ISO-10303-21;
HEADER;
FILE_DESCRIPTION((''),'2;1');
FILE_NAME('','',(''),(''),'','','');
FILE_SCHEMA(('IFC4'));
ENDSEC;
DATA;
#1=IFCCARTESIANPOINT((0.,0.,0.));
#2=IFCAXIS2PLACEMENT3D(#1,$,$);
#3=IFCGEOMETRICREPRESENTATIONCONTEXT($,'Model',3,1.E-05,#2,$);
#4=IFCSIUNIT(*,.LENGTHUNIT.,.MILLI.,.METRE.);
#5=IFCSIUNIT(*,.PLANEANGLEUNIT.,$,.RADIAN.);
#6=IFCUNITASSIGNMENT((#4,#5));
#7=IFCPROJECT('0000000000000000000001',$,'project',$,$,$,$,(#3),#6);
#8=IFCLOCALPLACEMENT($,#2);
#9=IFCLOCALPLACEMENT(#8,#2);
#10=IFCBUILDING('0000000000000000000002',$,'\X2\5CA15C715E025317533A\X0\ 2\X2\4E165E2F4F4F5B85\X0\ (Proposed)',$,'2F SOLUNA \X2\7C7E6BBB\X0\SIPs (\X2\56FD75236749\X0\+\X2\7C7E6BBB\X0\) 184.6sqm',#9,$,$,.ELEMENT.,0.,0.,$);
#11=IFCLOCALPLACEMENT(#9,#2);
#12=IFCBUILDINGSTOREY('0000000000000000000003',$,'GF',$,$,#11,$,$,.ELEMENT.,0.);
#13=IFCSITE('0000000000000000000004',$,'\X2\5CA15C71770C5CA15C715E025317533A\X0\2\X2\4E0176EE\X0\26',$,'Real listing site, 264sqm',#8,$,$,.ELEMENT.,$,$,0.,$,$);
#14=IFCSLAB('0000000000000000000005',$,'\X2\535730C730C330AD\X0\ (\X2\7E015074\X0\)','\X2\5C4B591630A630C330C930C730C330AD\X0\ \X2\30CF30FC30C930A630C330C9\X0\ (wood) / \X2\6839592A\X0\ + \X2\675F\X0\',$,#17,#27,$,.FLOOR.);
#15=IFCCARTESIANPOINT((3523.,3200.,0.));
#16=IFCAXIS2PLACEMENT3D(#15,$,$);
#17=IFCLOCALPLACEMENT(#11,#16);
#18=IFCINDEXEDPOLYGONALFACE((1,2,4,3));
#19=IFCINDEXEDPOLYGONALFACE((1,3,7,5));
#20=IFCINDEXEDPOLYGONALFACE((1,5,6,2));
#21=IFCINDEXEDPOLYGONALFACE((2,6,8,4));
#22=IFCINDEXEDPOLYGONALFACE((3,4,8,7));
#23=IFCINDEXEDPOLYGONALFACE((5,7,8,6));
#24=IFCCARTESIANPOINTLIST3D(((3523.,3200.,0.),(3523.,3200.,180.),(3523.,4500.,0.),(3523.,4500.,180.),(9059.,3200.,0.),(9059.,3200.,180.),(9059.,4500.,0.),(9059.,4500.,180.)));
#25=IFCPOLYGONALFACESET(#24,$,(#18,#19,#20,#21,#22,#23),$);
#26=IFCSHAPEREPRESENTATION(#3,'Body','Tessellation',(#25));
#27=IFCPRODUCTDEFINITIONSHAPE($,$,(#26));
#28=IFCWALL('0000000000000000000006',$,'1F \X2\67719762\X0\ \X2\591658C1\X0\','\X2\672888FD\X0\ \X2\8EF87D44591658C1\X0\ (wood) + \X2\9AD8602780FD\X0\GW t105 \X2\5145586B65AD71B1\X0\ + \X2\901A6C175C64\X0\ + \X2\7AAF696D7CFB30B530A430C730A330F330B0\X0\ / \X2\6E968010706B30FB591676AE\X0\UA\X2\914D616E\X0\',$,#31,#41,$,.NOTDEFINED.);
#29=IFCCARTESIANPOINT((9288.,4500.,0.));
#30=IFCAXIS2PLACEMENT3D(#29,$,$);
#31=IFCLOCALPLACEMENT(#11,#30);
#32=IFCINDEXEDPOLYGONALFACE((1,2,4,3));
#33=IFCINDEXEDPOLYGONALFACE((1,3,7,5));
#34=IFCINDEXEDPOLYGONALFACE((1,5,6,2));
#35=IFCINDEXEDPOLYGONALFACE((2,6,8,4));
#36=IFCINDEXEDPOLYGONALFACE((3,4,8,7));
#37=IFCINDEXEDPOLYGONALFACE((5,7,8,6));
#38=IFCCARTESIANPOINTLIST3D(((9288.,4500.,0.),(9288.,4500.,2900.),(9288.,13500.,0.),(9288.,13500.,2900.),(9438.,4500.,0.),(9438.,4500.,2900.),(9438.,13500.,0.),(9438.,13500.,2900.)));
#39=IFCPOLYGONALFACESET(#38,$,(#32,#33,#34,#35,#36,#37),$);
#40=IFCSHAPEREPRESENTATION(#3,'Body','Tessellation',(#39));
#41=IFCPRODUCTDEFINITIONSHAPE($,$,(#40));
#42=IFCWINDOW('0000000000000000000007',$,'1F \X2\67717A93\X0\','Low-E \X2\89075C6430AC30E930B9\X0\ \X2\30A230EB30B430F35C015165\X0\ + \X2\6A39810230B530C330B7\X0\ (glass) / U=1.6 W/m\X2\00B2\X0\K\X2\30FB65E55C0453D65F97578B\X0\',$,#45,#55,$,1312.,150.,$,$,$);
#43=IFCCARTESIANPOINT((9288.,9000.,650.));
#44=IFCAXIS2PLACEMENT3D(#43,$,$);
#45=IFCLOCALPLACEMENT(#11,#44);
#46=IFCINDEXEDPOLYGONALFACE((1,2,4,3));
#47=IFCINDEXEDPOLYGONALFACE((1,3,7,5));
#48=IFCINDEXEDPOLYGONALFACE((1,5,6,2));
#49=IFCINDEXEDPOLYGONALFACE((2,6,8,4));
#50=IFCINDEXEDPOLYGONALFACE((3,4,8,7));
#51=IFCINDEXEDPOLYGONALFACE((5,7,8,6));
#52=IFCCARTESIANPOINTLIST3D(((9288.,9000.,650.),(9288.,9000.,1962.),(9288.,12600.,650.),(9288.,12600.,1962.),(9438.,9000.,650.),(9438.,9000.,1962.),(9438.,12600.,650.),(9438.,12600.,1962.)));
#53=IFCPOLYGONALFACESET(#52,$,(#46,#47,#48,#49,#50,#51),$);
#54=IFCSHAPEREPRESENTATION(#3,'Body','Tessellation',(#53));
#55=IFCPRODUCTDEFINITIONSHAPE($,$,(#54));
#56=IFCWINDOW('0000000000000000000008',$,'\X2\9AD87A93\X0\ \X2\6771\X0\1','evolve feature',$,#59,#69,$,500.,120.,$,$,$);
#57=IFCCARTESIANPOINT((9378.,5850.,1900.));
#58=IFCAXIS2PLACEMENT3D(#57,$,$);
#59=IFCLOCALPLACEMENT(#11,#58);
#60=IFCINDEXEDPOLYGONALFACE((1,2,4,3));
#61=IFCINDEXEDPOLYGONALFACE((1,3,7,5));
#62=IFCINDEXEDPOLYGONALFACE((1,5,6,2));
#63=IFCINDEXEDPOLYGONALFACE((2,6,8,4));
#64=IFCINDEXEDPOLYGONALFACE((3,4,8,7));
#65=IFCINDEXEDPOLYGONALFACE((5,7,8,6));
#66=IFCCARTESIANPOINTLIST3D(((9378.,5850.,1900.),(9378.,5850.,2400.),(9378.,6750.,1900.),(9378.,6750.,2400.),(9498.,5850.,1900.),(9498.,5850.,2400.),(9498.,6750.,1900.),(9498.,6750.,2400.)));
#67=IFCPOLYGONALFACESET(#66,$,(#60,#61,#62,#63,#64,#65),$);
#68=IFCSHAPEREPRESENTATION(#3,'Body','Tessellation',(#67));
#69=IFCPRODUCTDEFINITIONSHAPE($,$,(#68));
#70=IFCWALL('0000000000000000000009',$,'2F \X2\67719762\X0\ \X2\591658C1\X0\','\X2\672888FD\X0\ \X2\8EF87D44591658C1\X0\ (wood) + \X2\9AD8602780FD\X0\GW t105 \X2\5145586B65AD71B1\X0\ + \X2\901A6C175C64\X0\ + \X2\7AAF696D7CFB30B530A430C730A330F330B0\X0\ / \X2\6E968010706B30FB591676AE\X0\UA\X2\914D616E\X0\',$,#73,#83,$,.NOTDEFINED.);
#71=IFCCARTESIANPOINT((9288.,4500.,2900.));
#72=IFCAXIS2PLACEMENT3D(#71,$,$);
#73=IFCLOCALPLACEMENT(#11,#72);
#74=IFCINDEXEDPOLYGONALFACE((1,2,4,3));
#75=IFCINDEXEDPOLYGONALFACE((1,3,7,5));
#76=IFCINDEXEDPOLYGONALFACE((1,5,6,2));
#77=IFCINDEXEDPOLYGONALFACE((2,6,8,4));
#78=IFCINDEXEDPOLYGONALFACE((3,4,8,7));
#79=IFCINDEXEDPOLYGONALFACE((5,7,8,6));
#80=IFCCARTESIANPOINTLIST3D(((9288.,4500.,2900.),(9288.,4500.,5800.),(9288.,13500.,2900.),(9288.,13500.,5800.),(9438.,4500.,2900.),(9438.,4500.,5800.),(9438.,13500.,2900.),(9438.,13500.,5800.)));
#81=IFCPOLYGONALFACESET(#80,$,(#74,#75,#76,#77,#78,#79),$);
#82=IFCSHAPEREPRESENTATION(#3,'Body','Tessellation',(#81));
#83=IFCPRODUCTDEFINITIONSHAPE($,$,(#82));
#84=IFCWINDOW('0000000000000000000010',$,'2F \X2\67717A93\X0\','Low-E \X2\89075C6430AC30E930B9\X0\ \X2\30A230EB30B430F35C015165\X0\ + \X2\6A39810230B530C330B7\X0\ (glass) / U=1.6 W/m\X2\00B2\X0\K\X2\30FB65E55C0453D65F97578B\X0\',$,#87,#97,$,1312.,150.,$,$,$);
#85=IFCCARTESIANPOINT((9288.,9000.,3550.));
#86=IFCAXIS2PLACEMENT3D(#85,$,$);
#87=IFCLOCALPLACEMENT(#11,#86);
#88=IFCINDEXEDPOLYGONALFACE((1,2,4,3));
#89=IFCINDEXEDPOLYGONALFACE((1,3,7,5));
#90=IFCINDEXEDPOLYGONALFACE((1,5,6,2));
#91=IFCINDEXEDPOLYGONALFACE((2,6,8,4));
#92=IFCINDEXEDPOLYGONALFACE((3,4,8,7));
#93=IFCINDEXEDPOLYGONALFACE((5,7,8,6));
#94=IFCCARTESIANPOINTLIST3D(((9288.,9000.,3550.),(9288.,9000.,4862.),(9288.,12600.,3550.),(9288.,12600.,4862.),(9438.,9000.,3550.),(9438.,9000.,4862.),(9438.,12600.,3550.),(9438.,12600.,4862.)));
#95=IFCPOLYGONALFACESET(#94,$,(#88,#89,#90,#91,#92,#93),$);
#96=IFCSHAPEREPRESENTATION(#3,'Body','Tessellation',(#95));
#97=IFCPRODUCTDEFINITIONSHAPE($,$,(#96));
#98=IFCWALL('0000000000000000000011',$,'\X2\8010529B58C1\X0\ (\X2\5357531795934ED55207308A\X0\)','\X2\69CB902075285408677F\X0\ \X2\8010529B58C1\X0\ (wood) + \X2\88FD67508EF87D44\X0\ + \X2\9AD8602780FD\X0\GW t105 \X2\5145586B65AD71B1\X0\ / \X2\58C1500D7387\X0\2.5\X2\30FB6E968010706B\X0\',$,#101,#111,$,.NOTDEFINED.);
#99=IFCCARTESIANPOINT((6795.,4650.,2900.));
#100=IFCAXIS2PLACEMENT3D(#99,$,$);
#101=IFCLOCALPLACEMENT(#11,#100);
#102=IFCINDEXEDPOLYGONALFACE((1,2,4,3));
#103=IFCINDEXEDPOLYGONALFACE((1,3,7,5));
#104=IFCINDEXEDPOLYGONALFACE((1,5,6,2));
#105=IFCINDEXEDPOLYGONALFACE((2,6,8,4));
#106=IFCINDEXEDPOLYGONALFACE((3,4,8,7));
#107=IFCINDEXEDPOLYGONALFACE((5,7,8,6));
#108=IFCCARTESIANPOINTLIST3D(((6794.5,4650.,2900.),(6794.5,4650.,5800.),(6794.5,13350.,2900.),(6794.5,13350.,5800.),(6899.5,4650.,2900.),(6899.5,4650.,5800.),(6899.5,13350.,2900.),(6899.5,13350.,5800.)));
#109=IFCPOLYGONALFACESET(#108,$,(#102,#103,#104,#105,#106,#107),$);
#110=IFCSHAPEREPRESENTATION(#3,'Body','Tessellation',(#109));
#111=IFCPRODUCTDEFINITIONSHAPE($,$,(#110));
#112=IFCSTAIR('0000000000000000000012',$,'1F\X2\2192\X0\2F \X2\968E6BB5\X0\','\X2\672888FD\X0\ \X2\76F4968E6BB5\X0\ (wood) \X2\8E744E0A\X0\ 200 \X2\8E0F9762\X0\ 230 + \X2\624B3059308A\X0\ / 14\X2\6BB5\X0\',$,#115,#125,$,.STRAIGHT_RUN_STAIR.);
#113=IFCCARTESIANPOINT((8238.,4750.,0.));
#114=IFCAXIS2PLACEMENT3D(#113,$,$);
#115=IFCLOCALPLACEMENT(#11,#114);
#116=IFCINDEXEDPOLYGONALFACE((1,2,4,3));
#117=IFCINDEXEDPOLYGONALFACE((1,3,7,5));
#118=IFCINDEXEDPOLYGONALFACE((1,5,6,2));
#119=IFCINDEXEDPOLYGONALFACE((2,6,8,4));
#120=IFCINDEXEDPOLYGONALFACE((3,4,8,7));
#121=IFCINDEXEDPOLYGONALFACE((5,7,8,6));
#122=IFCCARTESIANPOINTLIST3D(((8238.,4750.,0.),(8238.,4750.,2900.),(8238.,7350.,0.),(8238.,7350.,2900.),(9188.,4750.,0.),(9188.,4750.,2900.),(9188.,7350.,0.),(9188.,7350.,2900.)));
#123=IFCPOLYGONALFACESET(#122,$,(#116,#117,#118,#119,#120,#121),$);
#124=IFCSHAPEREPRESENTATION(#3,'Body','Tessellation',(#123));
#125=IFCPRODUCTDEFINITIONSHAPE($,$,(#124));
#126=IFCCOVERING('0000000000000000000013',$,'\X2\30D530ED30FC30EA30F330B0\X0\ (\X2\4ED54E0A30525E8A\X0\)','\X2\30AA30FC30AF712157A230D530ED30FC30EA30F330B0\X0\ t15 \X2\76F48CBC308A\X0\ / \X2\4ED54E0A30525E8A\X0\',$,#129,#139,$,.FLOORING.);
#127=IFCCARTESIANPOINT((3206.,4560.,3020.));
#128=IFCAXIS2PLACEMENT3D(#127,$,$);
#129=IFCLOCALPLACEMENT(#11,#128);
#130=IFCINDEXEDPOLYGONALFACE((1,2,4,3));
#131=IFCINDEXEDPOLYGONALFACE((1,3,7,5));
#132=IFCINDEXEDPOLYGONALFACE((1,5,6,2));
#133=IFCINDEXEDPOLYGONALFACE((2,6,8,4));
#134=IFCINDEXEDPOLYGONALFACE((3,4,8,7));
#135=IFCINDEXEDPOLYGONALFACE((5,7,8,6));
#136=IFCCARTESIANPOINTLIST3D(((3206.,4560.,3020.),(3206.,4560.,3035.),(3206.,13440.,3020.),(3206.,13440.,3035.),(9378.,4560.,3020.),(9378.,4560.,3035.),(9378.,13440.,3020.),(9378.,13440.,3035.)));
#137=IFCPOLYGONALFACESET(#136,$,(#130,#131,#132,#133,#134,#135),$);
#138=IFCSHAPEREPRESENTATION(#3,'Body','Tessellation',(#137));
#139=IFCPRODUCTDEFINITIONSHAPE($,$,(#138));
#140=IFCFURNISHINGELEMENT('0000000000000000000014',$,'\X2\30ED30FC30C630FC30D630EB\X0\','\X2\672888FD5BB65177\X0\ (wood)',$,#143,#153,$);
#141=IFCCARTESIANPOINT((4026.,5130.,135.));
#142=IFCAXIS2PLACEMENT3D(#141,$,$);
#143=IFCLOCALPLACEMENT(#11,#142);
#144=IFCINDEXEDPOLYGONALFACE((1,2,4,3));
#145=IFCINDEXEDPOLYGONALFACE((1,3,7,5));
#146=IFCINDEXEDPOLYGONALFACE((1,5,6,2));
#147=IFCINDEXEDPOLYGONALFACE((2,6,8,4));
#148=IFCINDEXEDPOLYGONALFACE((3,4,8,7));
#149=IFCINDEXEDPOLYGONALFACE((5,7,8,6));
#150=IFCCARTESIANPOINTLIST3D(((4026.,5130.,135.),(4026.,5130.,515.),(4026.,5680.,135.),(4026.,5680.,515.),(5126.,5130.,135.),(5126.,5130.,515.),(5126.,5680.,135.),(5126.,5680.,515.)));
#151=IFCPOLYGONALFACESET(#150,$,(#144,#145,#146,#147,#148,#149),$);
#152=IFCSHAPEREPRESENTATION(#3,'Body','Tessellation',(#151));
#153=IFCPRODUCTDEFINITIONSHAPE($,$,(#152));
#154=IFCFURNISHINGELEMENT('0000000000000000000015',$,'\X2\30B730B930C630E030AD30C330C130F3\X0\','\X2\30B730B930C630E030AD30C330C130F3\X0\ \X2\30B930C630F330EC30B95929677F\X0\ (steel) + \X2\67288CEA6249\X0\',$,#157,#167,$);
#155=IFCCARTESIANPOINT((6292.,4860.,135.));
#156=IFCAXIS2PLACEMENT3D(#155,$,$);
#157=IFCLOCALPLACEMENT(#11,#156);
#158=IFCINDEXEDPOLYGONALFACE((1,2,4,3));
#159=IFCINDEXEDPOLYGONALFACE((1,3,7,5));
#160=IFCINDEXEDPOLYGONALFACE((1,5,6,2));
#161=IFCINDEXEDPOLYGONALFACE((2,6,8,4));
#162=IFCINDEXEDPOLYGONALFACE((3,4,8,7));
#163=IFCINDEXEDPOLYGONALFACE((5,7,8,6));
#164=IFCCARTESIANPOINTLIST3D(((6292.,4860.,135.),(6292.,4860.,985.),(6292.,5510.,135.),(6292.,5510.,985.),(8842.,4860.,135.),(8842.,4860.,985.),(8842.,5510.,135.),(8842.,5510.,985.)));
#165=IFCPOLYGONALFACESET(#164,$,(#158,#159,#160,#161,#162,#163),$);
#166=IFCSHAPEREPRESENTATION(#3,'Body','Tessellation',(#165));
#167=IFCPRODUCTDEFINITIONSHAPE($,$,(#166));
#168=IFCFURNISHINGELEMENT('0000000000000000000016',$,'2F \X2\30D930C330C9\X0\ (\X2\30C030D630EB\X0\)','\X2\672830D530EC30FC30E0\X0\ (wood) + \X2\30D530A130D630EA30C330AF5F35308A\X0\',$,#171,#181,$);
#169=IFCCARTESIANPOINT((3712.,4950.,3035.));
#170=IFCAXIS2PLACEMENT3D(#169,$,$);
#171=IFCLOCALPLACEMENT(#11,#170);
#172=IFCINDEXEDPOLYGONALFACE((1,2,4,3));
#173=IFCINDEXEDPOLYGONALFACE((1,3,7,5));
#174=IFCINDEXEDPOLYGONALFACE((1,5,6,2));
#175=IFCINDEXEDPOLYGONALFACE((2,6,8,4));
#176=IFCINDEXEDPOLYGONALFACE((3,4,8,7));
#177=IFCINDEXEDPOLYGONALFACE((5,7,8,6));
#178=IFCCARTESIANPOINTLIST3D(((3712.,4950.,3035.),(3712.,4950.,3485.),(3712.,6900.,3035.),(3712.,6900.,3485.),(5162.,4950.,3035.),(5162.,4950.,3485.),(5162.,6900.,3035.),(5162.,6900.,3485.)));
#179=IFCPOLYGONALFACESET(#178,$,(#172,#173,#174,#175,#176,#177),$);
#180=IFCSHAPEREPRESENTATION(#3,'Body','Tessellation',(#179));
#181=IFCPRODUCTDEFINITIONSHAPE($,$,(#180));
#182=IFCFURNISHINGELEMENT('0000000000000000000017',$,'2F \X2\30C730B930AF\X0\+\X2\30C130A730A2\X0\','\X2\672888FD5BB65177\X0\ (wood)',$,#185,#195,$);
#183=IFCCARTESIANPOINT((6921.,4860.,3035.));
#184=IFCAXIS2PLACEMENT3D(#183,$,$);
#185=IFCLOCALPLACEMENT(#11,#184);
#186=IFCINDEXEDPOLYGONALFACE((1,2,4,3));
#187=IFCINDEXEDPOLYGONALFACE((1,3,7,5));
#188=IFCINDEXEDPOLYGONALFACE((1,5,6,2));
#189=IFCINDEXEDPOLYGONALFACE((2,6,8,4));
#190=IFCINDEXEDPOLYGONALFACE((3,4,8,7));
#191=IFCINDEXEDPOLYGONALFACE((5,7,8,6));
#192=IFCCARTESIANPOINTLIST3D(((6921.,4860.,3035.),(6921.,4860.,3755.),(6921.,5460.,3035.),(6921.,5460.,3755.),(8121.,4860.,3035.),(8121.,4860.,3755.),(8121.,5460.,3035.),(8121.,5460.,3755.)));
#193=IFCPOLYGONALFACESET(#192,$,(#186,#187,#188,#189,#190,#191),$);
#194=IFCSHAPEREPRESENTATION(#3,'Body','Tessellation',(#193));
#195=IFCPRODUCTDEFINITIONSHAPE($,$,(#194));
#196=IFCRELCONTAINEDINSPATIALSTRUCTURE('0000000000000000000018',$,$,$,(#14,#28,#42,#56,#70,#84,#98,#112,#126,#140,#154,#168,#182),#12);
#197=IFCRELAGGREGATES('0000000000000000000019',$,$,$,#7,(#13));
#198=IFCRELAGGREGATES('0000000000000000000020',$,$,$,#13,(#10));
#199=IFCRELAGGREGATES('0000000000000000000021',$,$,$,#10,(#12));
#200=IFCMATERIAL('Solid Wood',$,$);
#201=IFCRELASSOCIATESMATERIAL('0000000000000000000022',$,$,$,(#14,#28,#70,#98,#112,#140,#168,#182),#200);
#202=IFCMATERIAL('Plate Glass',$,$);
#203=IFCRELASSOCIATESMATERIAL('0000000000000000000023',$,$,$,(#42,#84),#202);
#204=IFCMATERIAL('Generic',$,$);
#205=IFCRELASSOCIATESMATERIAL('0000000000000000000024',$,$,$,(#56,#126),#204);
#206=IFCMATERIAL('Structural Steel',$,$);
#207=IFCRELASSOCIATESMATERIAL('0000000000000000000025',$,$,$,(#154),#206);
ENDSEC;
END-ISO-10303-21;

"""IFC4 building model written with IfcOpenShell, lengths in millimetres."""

from ifc_helpers import new_model, si_unit, frame, frame_2d, origin, place, context, project, spatial, rectangle, extrude, material, element, fill, save


model = new_model("IFC4")

# Units and contexts
model_context = context("Model", 3, precision=1e-05, world=origin())
ifc_project = project(units=[si_unit("LENGTHUNIT", "METRE", prefix="MILLI"), si_unit("PLANEANGLEUNIT", "RADIAN")], contexts=[model_context])

# Site, building, storey
site_placement = place(None, origin())
site = spatial("IfcSite", under=ifc_project, at=site_placement, Name="岡山県岡山市北区2丁目26", ObjectType="Real listing site, 264sqm", CompositionType="ELEMENT", RefElevation=0.0)
building_placement = place(site_placement, origin())
building = spatial("IfcBuilding", under=site, at=building_placement, Name="岡山市北区 2世帯住宅 (Proposed)", ObjectType="2F SOLUNA 籾殻SIPs (国産杉+籾殻) 184.6sqm", CompositionType="ELEMENT", ElevationOfRefHeight=0.0, ElevationOfTerrain=0.0)
storey_placement = place(building_placement, origin())
storey = spatial("IfcBuildingStorey", under=building, at=storey_placement, Name="GF", CompositionType="ELEMENT", Elevation=0.0)

# Slab
ifc_material_1 = material(Name="Solid Wood")
slab_placement = place(storey_placement, frame((3523.0, 3200.0, 0.0)))
element("IfcSlab", 1, at=slab_placement, inside=storey, material=ifc_material_1, Name="南デッキ (縁側)", Description="屋外ウッドデッキ ハードウッド (wood) / 根太 + 束", PredefinedType="FLOOR", context=model_context, shape_type="SweptSolid", body=[
    extrude(rectangle(XDim=5536.0, YDim=1300.0, at=frame_2d((2768.0, 650.0))), frame((3523.0, 3200.0, 0.0)), (0.0, 0.0, 1.0), 180.0),
])

# Wall, openings, windows
wall_1_placement = place(storey_placement, frame((9288.0, 4500.0, 0.0)))
wall_1 = element("IfcWall", 2, at=wall_1_placement, inside=storey, material=ifc_material_1, Name="1F 東面 外壁", Description="木製 軸組外壁 (wood) + 高性能GW t105 充填断熱 + 通気層 + 窯業系サイディング / 準耐火・外皮UA配慮", PredefinedType="NOTDEFINED", context=model_context, shape_type="SweptSolid", body=[
    extrude(rectangle(XDim=150.0, YDim=9000.0, at=frame_2d((75.0, 4500.0))), frame((9288.0, 4500.0, 0.0)), (0.0, 0.0, 1.0), 2900.0),
])
opening_1_placement = place(storey_placement, frame((9288.0, 9000.0, 650.0)))
opening_1 = element("IfcOpeningElement", 3, at=opening_1_placement, cuts=wall_1, PredefinedType="NOTDEFINED", context=model_context, shape_type="SweptSolid", body=[
    extrude(rectangle(XDim=150.0, YDim=3600.0, at=frame_2d((75.0, 1800.0))), frame((9288.0, 9000.0, 650.0)), (0.0, 0.0, 1.0), 1312.0),
])
opening_2_placement = place(storey_placement, frame((9378.0, 5850.0, 1900.0)))
opening_2 = element("IfcOpeningElement", 4, at=opening_2_placement, cuts=wall_1, PredefinedType="NOTDEFINED", context=model_context, shape_type="SweptSolid", body=[
    extrude(rectangle(XDim=120.0, YDim=900.0, at=frame_2d((60.0, 450.0))), frame((9378.0, 5850.0, 1900.0)), (0.0, 0.0, 1.0), 500.0),
])
ifc_material_2 = material(Name="Plate Glass")
window_1_placement = place(storey_placement, frame((9288.0, 9000.0, 650.0)))
window_1 = element("IfcWindow", 5, at=window_1_placement, inside=storey, material=ifc_material_2, Name="1F 東窓", Description="Low-E 複層ガラス アルゴン封入 + 樹脂サッシ (glass) / U=1.6 W/m²K・日射取得型", OverallHeight=1312.0, OverallWidth=150.0, context=model_context, shape_type="SweptSolid", body=[
    extrude(rectangle(XDim=150.0, YDim=3600.0, at=frame_2d((75.0, 1800.0))), frame((9288.0, 9000.0, 650.0)), (0.0, 0.0, 1.0), 1312.0),
])
fill(opening_1, window_1)
ifc_material_3 = material(Name="Generic")
window_2_placement = place(storey_placement, frame((9378.0, 5850.0, 1900.0)))
window_2 = element("IfcWindow", 6, at=window_2_placement, inside=storey, material=ifc_material_3, Name="高窓 東1", Description="evolve feature", OverallHeight=500.0, OverallWidth=120.0, context=model_context, shape_type="SweptSolid", body=[
    extrude(rectangle(XDim=120.0, YDim=900.0, at=frame_2d((60.0, 450.0))), frame((9378.0, 5850.0, 1900.0)), (0.0, 0.0, 1.0), 500.0),
])
fill(opening_2, window_2)

# Wall, opening, window
wall_2_placement = place(storey_placement, frame((9288.0, 4500.0, 2900.0)))
wall_2 = element("IfcWall", 7, at=wall_2_placement, inside=storey, material=ifc_material_1, Name="2F 東面 外壁", Description="木製 軸組外壁 (wood) + 高性能GW t105 充填断熱 + 通気層 + 窯業系サイディング / 準耐火・外皮UA配慮", PredefinedType="NOTDEFINED", context=model_context, shape_type="SweptSolid", body=[
    extrude(rectangle(XDim=150.0, YDim=9000.0, at=frame_2d((75.0, 4500.0))), frame((9288.0, 4500.0, 2900.0)), (0.0, 0.0, 1.0), 2900.0),
])
opening_3_placement = place(storey_placement, frame((9288.0, 9000.0, 3550.0)))
opening_3 = element("IfcOpeningElement", 8, at=opening_3_placement, cuts=wall_2, PredefinedType="NOTDEFINED", context=model_context, shape_type="SweptSolid", body=[
    extrude(rectangle(XDim=150.0, YDim=3600.0, at=frame_2d((75.0, 1800.0))), frame((9288.0, 9000.0, 3550.0)), (0.0, 0.0, 1.0), 1312.0),
])
window_3_placement = place(storey_placement, frame((9288.0, 9000.0, 3550.0)))
window_3 = element("IfcWindow", 9, at=window_3_placement, inside=storey, material=ifc_material_2, Name="2F 東窓", Description="Low-E 複層ガラス アルゴン封入 + 樹脂サッシ (glass) / U=1.6 W/m²K・日射取得型", OverallHeight=1312.0, OverallWidth=150.0, context=model_context, shape_type="SweptSolid", body=[
    extrude(rectangle(XDim=150.0, YDim=3600.0, at=frame_2d((75.0, 1800.0))), frame((9288.0, 9000.0, 3550.0)), (0.0, 0.0, 1.0), 1312.0),
])
fill(opening_3, window_3)

# Wall
wall_3_placement = place(storey_placement, frame((6795.0, 4650.0, 2900.0)))
element("IfcWall", 10, at=wall_3_placement, inside=storey, material=ifc_material_1, Name="耐力壁 (南北間仕切り)", Description="構造用合板 耐力壁 (wood) + 製材軸組 + 高性能GW t105 充填断熱 / 壁倍率2.5・準耐火", PredefinedType="NOTDEFINED", context=model_context, shape_type="SweptSolid", body=[
    extrude(rectangle(XDim=105.0, YDim=8700.0, at=frame_2d((52.0, 4350.0))), frame((6795.0, 4650.0, 2900.0)), (0.0, 0.0, 1.0), 2900.0),
])

# Stair
stair_placement = place(storey_placement, frame((8238.0, 4750.0, 0.0)))
element("IfcStair", 11, at=stair_placement, inside=storey, material=ifc_material_1, Name="1F→2F 階段", Description="木製 直階段 (wood) 蹴上 200 踏面 230 + 手すり / 14段", PredefinedType="STRAIGHT_RUN_STAIR", context=model_context, shape_type="SweptSolid", body=[
    extrude(rectangle(XDim=950.0, YDim=2600.0, at=frame_2d((475.0, 1300.0))), frame((8238.0, 4750.0, 0.0)), (0.0, 0.0, 1.0), 2900.0),
])

# Covering
covering_placement = place(storey_placement, frame((3206.0, 4560.0, 3020.0)))
element("IfcCovering", 12, at=covering_placement, inside=storey, material=ifc_material_3, Name="フローリング (仕上げ床)", Description="オーク無垢フローリング t15 直貼り / 仕上げ床", PredefinedType="FLOORING", context=model_context, shape_type="SweptSolid", body=[
    extrude(rectangle(XDim=6172.0, YDim=8880.0, at=frame_2d((3086.0, 4440.0))), frame((3206.0, 4560.0, 3020.0)), (0.0, 0.0, 1.0), 15.0),
])

# Furnishing elements
furnishing_1_placement = place(storey_placement, frame((4026.0, 5130.0, 135.0)))
element("IfcFurnishingElement", 13, at=furnishing_1_placement, inside=storey, material=ifc_material_1, Name="ローテーブル", Description="木製家具 (wood)", context=model_context, shape_type="SweptSolid", body=[
    extrude(rectangle(XDim=1100.0, YDim=550.0, at=frame_2d((550.0, 275.0))), frame((4026.0, 5130.0, 135.0)), (0.0, 0.0, 1.0), 380.0),
])
ifc_material_4 = material(Name="Structural Steel")
furnishing_2_placement = place(storey_placement, frame((6292.0, 4860.0, 135.0)))
element("IfcFurnishingElement", 14, at=furnishing_2_placement, inside=storey, material=ifc_material_4, Name="システムキッチン", Description="システムキッチン ステンレス天板 (steel) + 木質扉", context=model_context, shape_type="SweptSolid", body=[
    extrude(rectangle(XDim=2550.0, YDim=650.0, at=frame_2d((1275.0, 325.0))), frame((6292.0, 4860.0, 135.0)), (0.0, 0.0, 1.0), 850.0),
])
furnishing_3_placement = place(storey_placement, frame((3712.0, 4950.0, 3035.0)))
element("IfcFurnishingElement", 15, at=furnishing_3_placement, inside=storey, material=ifc_material_1, Name="2F ベッド (ダブル)", Description="木フレーム (wood) + ファブリック張り", context=model_context, shape_type="SweptSolid", body=[
    extrude(rectangle(XDim=1450.0, YDim=1950.0, at=frame_2d((725.0, 975.0))), frame((3712.0, 4950.0, 3035.0)), (0.0, 0.0, 1.0), 450.0),
])
furnishing_4_placement = place(storey_placement, frame((6921.0, 4860.0, 3035.0)))
element("IfcFurnishingElement", 16, at=furnishing_4_placement, inside=storey, material=ifc_material_1, Name="2F デスク+チェア", Description="木製家具 (wood)", context=model_context, shape_type="SweptSolid", body=[
    extrude(rectangle(XDim=1200.0, YDim=600.0, at=frame_2d((600.0, 300.0))), frame((6921.0, 4860.0, 3035.0)), (0.0, 0.0, 1.0), 720.0),
])

save(model, "model.ifc")
